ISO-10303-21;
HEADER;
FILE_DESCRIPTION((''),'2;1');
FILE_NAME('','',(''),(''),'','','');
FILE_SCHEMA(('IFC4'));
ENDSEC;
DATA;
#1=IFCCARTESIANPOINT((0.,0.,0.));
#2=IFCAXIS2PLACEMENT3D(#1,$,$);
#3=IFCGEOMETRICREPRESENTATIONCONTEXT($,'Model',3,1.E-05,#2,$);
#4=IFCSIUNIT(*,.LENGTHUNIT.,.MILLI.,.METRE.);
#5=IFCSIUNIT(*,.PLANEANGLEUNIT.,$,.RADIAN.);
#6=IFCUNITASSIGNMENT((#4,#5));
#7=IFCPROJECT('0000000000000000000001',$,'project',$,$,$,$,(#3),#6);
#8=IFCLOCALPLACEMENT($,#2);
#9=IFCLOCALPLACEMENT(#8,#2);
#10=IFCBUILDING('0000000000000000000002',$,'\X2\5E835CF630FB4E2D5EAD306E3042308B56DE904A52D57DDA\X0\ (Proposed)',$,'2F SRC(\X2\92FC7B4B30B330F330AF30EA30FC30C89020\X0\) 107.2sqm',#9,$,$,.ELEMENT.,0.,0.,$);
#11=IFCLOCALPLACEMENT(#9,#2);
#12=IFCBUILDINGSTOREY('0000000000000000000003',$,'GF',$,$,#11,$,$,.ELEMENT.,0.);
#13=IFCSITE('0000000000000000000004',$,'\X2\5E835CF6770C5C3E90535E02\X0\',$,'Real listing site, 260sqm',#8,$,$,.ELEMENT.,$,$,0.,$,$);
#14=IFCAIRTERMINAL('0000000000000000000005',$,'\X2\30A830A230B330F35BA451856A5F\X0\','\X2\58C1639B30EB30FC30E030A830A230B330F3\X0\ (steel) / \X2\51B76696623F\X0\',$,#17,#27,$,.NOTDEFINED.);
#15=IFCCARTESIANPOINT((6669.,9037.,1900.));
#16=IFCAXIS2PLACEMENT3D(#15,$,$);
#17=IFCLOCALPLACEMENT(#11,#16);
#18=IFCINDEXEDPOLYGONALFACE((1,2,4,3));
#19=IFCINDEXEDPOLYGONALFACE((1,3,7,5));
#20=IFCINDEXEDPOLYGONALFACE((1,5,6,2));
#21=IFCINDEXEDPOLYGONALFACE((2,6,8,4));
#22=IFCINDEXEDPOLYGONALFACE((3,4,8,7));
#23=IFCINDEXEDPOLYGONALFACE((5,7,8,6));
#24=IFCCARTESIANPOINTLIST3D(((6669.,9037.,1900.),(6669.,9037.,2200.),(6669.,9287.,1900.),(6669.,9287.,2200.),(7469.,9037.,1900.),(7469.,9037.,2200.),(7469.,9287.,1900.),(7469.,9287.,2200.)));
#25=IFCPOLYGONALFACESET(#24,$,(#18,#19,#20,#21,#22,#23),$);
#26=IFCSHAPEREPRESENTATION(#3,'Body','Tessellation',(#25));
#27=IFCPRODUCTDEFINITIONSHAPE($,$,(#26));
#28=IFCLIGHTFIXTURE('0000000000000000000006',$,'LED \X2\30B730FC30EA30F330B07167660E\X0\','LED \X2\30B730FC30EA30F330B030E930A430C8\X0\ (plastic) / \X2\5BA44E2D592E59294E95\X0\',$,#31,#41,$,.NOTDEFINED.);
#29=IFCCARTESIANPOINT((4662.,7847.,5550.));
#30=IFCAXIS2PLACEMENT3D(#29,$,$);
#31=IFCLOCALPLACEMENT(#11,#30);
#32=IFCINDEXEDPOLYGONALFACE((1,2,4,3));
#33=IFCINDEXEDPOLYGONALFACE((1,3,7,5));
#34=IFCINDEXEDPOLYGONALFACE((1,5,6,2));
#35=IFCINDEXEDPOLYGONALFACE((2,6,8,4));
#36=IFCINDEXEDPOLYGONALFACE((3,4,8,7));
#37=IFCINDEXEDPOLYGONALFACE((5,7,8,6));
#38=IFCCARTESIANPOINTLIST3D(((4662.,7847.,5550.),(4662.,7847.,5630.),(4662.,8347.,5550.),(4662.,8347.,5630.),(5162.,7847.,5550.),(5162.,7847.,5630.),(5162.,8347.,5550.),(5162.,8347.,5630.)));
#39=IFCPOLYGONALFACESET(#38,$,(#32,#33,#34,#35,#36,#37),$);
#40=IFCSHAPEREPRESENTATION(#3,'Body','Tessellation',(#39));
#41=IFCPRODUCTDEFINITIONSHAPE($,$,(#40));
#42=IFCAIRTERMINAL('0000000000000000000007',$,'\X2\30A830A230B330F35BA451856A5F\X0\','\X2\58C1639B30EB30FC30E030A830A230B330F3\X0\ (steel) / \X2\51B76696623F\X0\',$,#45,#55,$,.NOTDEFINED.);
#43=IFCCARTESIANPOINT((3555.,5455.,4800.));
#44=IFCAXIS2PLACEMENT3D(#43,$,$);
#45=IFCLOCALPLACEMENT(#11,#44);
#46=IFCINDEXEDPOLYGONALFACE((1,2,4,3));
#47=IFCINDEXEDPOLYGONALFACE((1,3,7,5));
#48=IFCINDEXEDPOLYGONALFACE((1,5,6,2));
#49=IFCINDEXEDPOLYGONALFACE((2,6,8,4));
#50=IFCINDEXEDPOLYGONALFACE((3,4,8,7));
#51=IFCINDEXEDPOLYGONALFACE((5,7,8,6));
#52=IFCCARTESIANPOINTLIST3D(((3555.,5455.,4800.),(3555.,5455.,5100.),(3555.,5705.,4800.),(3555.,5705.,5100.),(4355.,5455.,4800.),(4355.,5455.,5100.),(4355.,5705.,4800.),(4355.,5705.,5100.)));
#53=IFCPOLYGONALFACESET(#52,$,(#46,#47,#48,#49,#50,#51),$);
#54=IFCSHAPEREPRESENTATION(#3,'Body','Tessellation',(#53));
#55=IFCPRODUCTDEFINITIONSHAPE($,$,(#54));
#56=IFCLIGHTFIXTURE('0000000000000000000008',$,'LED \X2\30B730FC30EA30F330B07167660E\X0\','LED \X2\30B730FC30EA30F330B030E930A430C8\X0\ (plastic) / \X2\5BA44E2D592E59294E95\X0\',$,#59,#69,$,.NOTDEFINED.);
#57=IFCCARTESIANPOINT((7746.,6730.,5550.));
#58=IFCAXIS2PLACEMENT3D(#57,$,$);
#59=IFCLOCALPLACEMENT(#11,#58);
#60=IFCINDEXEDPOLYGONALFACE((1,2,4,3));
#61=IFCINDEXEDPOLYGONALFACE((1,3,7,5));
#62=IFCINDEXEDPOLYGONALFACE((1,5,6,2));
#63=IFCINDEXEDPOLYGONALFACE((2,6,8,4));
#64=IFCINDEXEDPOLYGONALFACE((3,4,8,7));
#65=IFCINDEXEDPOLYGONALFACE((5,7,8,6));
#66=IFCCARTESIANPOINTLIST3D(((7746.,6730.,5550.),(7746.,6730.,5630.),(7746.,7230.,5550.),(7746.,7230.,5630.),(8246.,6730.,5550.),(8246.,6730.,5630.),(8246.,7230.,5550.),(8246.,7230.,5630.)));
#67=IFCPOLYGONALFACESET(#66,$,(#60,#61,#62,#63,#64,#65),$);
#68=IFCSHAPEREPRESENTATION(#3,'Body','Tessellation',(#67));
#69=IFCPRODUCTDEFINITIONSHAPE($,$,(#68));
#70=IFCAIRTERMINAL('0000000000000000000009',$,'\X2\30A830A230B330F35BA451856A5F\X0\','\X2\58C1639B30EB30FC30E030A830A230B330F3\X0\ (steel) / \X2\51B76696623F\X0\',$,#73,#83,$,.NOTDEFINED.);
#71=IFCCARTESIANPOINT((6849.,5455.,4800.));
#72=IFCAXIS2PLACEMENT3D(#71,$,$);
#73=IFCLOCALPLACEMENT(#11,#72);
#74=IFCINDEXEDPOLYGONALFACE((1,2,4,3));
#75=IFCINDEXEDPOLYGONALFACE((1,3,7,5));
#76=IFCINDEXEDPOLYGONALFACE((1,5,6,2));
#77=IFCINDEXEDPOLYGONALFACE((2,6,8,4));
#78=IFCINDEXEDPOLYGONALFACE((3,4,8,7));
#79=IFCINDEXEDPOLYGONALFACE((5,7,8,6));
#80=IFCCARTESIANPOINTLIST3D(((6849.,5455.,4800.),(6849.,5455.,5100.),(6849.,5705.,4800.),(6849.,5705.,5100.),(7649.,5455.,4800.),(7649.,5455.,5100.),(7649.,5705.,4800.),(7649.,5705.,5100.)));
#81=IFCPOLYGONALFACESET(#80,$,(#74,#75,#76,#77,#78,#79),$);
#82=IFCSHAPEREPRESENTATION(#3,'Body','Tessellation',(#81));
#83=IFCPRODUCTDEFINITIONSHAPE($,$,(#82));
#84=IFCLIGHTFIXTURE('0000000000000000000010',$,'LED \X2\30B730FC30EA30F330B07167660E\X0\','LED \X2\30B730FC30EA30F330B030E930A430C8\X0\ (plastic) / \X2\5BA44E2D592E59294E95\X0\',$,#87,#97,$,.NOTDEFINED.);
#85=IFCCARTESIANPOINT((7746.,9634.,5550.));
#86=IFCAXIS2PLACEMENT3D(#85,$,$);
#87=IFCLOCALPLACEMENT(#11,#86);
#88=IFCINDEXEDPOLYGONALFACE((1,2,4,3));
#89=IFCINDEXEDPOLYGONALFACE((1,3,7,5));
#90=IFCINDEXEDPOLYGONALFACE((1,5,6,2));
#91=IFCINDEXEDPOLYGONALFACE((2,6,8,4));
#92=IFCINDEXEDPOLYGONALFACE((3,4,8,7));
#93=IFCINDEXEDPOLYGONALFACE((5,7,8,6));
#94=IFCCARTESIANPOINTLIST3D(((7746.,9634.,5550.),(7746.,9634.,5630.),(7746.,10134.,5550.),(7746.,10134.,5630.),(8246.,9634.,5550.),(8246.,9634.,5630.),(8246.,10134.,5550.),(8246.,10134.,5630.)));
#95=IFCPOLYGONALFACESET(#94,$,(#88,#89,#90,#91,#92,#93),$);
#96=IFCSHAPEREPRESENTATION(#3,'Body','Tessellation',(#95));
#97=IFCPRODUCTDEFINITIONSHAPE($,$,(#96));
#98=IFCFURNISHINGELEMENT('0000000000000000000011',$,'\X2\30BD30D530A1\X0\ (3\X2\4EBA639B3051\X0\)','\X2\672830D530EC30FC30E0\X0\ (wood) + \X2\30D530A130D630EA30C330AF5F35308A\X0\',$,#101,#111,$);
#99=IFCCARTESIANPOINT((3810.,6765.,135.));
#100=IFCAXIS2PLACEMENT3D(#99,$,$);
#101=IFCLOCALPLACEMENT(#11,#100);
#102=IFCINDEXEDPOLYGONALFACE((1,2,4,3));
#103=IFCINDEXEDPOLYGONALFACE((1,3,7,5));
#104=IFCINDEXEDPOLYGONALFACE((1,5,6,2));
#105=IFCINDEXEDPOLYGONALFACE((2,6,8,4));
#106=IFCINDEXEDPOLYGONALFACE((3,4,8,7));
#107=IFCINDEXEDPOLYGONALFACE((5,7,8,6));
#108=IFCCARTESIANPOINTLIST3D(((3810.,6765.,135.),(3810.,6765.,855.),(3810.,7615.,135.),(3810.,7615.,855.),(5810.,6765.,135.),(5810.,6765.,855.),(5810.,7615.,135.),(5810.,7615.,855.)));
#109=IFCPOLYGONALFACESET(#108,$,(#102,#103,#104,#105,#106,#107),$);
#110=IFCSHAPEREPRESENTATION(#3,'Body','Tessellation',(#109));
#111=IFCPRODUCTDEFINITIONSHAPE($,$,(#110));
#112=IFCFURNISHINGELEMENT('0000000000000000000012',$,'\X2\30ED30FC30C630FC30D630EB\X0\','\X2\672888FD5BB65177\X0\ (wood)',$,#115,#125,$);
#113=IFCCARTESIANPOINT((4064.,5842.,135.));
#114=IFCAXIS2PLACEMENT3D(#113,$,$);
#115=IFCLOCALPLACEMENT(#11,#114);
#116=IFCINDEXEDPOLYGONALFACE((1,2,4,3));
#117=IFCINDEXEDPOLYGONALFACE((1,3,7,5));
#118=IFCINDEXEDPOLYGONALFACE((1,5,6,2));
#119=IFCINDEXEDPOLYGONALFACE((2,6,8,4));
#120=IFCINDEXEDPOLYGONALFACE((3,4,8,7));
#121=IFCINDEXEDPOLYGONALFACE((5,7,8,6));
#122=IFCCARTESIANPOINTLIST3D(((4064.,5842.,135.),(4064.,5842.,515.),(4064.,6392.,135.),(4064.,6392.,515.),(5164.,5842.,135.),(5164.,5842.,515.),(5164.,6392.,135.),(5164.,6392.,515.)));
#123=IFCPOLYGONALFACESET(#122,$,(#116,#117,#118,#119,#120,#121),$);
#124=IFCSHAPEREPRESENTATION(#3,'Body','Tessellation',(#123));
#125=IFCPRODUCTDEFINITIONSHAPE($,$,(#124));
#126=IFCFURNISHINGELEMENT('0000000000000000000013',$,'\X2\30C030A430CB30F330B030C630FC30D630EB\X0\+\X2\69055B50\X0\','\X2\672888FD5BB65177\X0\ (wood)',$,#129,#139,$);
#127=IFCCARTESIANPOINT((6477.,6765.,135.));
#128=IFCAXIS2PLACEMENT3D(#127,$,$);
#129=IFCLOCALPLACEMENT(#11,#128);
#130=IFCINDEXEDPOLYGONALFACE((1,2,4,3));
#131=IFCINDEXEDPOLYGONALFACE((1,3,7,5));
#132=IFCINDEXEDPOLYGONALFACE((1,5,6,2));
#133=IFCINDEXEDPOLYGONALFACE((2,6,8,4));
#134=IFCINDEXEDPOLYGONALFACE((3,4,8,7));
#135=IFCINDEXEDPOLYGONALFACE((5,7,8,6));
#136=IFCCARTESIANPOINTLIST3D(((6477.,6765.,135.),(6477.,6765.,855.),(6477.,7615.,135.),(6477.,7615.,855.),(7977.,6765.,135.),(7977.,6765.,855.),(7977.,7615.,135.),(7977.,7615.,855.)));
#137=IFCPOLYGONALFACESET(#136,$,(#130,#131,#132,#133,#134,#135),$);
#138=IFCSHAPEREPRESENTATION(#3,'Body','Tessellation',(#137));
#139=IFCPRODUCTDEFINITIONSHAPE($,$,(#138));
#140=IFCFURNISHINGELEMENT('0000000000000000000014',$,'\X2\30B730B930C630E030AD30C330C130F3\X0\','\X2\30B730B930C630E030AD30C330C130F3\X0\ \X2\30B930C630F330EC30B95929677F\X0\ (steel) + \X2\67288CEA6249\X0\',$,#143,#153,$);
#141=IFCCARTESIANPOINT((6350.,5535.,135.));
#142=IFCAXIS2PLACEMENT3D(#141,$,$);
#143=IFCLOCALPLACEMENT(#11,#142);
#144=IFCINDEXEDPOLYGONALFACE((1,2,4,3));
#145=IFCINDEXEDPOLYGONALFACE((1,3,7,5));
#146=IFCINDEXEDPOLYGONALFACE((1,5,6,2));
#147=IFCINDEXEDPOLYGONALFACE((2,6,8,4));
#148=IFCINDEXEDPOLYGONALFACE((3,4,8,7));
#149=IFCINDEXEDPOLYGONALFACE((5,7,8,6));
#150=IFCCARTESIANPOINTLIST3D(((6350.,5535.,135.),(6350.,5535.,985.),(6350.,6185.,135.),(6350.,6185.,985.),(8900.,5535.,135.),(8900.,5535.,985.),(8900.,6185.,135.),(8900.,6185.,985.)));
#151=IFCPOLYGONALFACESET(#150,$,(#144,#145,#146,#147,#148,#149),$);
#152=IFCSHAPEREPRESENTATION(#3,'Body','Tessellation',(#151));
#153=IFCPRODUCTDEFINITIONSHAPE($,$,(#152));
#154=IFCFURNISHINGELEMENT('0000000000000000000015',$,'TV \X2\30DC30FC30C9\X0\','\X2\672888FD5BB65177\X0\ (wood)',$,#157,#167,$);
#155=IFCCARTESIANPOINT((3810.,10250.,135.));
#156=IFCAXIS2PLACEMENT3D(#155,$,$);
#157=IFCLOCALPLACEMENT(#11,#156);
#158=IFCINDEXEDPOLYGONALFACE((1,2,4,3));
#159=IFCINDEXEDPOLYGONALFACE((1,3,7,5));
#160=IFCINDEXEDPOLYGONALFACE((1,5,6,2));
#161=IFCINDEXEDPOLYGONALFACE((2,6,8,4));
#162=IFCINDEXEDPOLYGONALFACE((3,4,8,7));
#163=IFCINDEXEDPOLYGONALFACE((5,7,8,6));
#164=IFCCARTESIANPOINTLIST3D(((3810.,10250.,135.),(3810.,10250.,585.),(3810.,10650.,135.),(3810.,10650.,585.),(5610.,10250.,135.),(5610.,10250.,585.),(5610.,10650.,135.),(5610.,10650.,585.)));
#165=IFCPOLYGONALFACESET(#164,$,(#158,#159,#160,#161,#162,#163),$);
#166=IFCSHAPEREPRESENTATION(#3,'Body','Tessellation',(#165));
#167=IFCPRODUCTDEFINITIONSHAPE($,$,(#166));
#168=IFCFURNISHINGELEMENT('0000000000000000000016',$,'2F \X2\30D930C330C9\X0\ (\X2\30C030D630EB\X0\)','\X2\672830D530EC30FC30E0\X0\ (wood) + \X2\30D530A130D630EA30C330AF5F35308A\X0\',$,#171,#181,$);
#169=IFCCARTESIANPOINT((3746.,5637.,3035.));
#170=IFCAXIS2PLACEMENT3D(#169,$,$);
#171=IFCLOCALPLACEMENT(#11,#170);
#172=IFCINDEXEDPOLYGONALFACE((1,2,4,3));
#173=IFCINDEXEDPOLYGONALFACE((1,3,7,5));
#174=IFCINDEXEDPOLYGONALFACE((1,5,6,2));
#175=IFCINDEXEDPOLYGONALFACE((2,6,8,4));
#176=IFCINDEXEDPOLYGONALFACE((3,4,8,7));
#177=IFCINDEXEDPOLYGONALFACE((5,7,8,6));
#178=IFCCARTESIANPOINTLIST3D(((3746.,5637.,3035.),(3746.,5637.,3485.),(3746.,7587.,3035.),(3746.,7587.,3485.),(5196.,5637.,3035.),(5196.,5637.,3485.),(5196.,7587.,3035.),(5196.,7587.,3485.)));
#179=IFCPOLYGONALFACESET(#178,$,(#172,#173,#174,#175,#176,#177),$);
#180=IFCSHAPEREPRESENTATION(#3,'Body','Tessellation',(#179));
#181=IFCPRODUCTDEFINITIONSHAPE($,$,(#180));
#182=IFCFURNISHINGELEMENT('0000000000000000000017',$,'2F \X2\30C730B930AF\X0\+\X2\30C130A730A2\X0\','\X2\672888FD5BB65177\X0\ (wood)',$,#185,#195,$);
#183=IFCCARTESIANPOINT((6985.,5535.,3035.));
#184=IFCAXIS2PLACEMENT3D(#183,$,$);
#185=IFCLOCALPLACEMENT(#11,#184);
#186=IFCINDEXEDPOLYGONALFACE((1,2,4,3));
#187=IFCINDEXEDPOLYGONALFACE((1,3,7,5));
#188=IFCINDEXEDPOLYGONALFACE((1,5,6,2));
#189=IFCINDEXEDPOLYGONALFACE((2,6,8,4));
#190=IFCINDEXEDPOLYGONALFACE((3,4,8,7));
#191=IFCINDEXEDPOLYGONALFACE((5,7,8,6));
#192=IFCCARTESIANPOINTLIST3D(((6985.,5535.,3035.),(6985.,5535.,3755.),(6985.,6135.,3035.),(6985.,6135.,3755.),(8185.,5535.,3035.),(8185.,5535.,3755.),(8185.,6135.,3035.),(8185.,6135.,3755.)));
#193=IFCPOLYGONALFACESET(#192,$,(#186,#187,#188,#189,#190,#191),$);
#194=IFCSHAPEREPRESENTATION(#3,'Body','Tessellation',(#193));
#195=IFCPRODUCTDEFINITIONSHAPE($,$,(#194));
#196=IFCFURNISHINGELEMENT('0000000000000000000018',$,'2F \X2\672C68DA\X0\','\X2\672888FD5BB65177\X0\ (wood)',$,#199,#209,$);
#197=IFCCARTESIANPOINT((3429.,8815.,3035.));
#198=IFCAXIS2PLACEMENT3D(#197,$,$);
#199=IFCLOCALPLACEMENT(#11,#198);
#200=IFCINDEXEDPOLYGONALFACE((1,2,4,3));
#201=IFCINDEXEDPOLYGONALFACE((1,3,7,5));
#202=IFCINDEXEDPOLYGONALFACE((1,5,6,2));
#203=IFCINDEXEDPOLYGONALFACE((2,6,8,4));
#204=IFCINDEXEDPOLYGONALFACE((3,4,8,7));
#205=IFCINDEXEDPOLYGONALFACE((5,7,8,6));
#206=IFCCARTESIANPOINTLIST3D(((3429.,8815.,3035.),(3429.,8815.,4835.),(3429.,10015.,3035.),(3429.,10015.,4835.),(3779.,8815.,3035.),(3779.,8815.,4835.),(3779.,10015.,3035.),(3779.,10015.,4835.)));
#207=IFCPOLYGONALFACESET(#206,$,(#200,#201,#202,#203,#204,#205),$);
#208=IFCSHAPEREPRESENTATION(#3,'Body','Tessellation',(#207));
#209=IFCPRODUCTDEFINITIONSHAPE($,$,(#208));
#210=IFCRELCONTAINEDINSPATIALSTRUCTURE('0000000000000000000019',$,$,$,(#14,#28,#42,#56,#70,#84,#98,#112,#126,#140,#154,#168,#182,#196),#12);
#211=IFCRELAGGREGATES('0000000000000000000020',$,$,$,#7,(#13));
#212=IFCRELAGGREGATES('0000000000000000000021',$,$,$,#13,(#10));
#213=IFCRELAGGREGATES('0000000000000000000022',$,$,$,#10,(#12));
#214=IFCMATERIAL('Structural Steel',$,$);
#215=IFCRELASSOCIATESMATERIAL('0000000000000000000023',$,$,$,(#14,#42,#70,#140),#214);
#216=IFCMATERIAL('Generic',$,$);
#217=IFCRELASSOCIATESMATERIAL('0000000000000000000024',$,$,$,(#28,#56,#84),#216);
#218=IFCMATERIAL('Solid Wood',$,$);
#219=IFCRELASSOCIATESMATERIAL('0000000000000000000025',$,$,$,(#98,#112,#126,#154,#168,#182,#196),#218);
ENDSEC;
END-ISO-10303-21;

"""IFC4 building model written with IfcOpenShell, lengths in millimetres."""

from ifc_helpers import new_model, si_unit, frame, frame_2d, origin, place, context, project, spatial, rectangle, extrude, material, element, save


model = new_model("IFC4")

# Units and contexts
model_context = context("Model", 3, precision=1e-05, world=origin())
ifc_project = project(units=[si_unit("LENGTHUNIT", "METRE", prefix="MILLI"), si_unit("PLANEANGLEUNIT", "RADIAN")], contexts=[model_context])

# Site, building, storey
site_placement = place(None, origin())
site = spatial("IfcSite", under=ifc_project, at=site_placement, Name="広島県尾道市", ObjectType="Real listing site, 260sqm", CompositionType="ELEMENT", RefElevation=0.0)
building_placement = place(site_placement, origin())
building = spatial("IfcBuilding", under=site, at=building_placement, Name="広島・中庭のある回遊動線 (Proposed)", ObjectType="2F SRC(鋼筋コンクリート造) 107.2sqm", CompositionType="ELEMENT", ElevationOfRefHeight=0.0, ElevationOfTerrain=0.0)
storey_placement = place(building_placement, origin())
storey = spatial("IfcBuildingStorey", under=building, at=storey_placement, Name="GF", CompositionType="ELEMENT", Elevation=0.0)

# Shared definitions
ifc_material_1 = material(Name="Solid Wood")

# Shared definitions
ifc_material_2 = material(Name="Structural Steel")

# Shared definitions
ifc_material_3 = material(Name="Generic")

# Air terminal
air_terminal_1_placement = place(storey_placement, frame((6669.0, 9037.0, 1900.0)))
element("IfcAirTerminal", 1, at=air_terminal_1_placement, inside=storey, material=ifc_material_2, Name="エアコン室内機", Description="壁掛ルームエアコン (steel) / 冷暖房", PredefinedType="NOTDEFINED", context=model_context, shape_type="SweptSolid", body=[
    extrude(rectangle(XDim=800.0, YDim=250.0, at=frame_2d((400.0, 125.0))), frame((6669.0, 9037.0, 1900.0)), (0.0, 0.0, 1.0), 300.0),
])

# Light fixture
light_fixture_1_placement = place(storey_placement, frame((4662.0, 7847.0, 5550.0)))
element("IfcLightFixture", 2, at=light_fixture_1_placement, inside=storey, material=ifc_material_3, Name="LED シーリング照明", Description="LED シーリングライト (plastic) / 室中央天井", PredefinedType="NOTDEFINED", context=model_context, shape_type="SweptSolid", body=[
    extrude(rectangle(XDim=500.0, YDim=500.0, at=frame_2d((250.0, 250.0))), frame((4662.0, 7847.0, 5550.0)), (0.0, 0.0, 1.0), 80.0),
])

# Air terminal
air_terminal_2_placement = place(storey_placement, frame((3555.0, 5455.0, 4800.0)))
element("IfcAirTerminal", 3, at=air_terminal_2_placement, inside=storey, material=ifc_material_2, Name="エアコン室内機", Description="壁掛ルームエアコン (steel) / 冷暖房", PredefinedType="NOTDEFINED", context=model_context, shape_type="SweptSolid", body=[
    extrude(rectangle(XDim=800.0, YDim=250.0, at=frame_2d((400.0, 125.0))), frame((3555.0, 5455.0, 4800.0)), (0.0, 0.0, 1.0), 300.0),
])

# Light fixture
light_fixture_2_placement = place(storey_placement, frame((7746.0, 6730.0, 5550.0)))
element("IfcLightFixture", 4, at=light_fixture_2_placement, inside=storey, material=ifc_material_3, Name="LED シーリング照明", Description="LED シーリングライト (plastic) / 室中央天井", PredefinedType="NOTDEFINED", context=model_context, shape_type="SweptSolid", body=[
    extrude(rectangle(XDim=500.0, YDim=500.0, at=frame_2d((250.0, 250.0))), frame((7746.0, 6730.0, 5550.0)), (0.0, 0.0, 1.0), 80.0),
])

# Air terminal
air_terminal_3_placement = place(storey_placement, frame((6849.0, 5455.0, 4800.0)))
element("IfcAirTerminal", 5, at=air_terminal_3_placement, inside=storey, material=ifc_material_2, Name="エアコン室内機", Description="壁掛ルームエアコン (steel) / 冷暖房", PredefinedType="NOTDEFINED", context=model_context, shape_type="SweptSolid", body=[
    extrude(rectangle(XDim=800.0, YDim=250.0, at=frame_2d((400.0, 125.0))), frame((6849.0, 5455.0, 4800.0)), (0.0, 0.0, 1.0), 300.0),
])

# Light fixture
light_fixture_3_placement = place(storey_placement, frame((7746.0, 9634.0, 5550.0)))
element("IfcLightFixture", 6, at=light_fixture_3_placement, inside=storey, material=ifc_material_3, Name="LED シーリング照明", Description="LED シーリングライト (plastic) / 室中央天井", PredefinedType="NOTDEFINED", context=model_context, shape_type="SweptSolid", body=[
    extrude(rectangle(XDim=500.0, YDim=500.0, at=frame_2d((250.0, 250.0))), frame((7746.0, 9634.0, 5550.0)), (0.0, 0.0, 1.0), 80.0),
])

# Furnishing elements
furnishing_1_placement = place(storey_placement, frame((3810.0, 6765.0, 135.0)))
element("IfcFurnishingElement", 7, at=furnishing_1_placement, inside=storey, material=ifc_material_1, Name="ソファ (3人掛け)", Description="木フレーム (wood) + ファブリック張り", context=model_context, shape_type="SweptSolid", body=[
    extrude(rectangle(XDim=2000.0, YDim=850.0, at=frame_2d((1000.0, 425.0))), frame((3810.0, 6765.0, 135.0)), (0.0, 0.0, 1.0), 720.0),
])
furnishing_2_placement = place(storey_placement, frame((4064.0, 5842.0, 135.0)))
element("IfcFurnishingElement", 8, at=furnishing_2_placement, inside=storey, material=ifc_material_1, Name="ローテーブル", Description="木製家具 (wood)", context=model_context, shape_type="SweptSolid", body=[
    extrude(rectangle(XDim=1100.0, YDim=550.0, at=frame_2d((550.0, 275.0))), frame((4064.0, 5842.0, 135.0)), (0.0, 0.0, 1.0), 380.0),
])
furnishing_3_placement = place(storey_placement, frame((6477.0, 6765.0, 135.0)))
element("IfcFurnishingElement", 9, at=furnishing_3_placement, inside=storey, material=ifc_material_1, Name="ダイニングテーブル+椅子", Description="木製家具 (wood)", context=model_context, shape_type="SweptSolid", body=[
    extrude(rectangle(XDim=1500.0, YDim=850.0, at=frame_2d((750.0, 425.0))), frame((6477.0, 6765.0, 135.0)), (0.0, 0.0, 1.0), 720.0),
])
furnishing_4_placement = place(storey_placement, frame((6350.0, 5535.0, 135.0)))
element("IfcFurnishingElement", 10, at=furnishing_4_placement, inside=storey, material=ifc_material_2, Name="システムキッチン", Description="システムキッチン ステンレス天板 (steel) + 木質扉", context=model_context, shape_type="SweptSolid", body=[
    extrude(rectangle(XDim=2550.0, YDim=650.0, at=frame_2d((1275.0, 325.0))), frame((6350.0, 5535.0, 135.0)), (0.0, 0.0, 1.0), 850.0),
])
furnishing_5_placement = place(storey_placement, frame((3810.0, 10250.0, 135.0)))
element("IfcFurnishingElement", 11, at=furnishing_5_placement, inside=storey, material=ifc_material_1, Name="TV ボード", Description="木製家具 (wood)", context=model_context, shape_type="SweptSolid", body=[
    extrude(rectangle(XDim=1800.0, YDim=400.0, at=frame_2d((900.0, 200.0))), frame((3810.0, 10250.0, 135.0)), (0.0, 0.0, 1.0), 450.0),
])
furnishing_6_placement = place(storey_placement, frame((3746.0, 5637.0, 3035.0)))
element("IfcFurnishingElement", 12, at=furnishing_6_placement, inside=storey, material=ifc_material_1, Name="2F ベッド (ダブル)", Description="木フレーム (wood) + ファブリック張り", context=model_context, shape_type="SweptSolid", body=[
    extrude(rectangle(XDim=1450.0, YDim=1950.0, at=frame_2d((725.0, 975.0))), frame((3746.0, 5637.0, 3035.0)), (0.0, 0.0, 1.0), 450.0),
])
furnishing_7_placement = place(storey_placement, frame((6985.0, 5535.0, 3035.0)))
element("IfcFurnishingElement", 13, at=furnishing_7_placement, inside=storey, material=ifc_material_1, Name="2F デスク+チェア", Description="木製家具 (wood)", context=model_context, shape_type="SweptSolid", body=[
    extrude(rectangle(XDim=1200.0, YDim=600.0, at=frame_2d((600.0, 300.0))), frame((6985.0, 5535.0, 3035.0)), (0.0, 0.0, 1.0), 720.0),
])
furnishing_8_placement = place(storey_placement, frame((3429.0, 8815.0, 3035.0)))
element("IfcFurnishingElement", 14, at=furnishing_8_placement, inside=storey, material=ifc_material_1, Name="2F 本棚", Description="木製家具 (wood)", context=model_context, shape_type="SweptSolid", body=[
    extrude(rectangle(XDim=350.0, YDim=1200.0, at=frame_2d((175.0, 600.0))), frame((3429.0, 8815.0, 3035.0)), (0.0, 0.0, 1.0), 1800.0),
])

save(model, "model.ifc")
